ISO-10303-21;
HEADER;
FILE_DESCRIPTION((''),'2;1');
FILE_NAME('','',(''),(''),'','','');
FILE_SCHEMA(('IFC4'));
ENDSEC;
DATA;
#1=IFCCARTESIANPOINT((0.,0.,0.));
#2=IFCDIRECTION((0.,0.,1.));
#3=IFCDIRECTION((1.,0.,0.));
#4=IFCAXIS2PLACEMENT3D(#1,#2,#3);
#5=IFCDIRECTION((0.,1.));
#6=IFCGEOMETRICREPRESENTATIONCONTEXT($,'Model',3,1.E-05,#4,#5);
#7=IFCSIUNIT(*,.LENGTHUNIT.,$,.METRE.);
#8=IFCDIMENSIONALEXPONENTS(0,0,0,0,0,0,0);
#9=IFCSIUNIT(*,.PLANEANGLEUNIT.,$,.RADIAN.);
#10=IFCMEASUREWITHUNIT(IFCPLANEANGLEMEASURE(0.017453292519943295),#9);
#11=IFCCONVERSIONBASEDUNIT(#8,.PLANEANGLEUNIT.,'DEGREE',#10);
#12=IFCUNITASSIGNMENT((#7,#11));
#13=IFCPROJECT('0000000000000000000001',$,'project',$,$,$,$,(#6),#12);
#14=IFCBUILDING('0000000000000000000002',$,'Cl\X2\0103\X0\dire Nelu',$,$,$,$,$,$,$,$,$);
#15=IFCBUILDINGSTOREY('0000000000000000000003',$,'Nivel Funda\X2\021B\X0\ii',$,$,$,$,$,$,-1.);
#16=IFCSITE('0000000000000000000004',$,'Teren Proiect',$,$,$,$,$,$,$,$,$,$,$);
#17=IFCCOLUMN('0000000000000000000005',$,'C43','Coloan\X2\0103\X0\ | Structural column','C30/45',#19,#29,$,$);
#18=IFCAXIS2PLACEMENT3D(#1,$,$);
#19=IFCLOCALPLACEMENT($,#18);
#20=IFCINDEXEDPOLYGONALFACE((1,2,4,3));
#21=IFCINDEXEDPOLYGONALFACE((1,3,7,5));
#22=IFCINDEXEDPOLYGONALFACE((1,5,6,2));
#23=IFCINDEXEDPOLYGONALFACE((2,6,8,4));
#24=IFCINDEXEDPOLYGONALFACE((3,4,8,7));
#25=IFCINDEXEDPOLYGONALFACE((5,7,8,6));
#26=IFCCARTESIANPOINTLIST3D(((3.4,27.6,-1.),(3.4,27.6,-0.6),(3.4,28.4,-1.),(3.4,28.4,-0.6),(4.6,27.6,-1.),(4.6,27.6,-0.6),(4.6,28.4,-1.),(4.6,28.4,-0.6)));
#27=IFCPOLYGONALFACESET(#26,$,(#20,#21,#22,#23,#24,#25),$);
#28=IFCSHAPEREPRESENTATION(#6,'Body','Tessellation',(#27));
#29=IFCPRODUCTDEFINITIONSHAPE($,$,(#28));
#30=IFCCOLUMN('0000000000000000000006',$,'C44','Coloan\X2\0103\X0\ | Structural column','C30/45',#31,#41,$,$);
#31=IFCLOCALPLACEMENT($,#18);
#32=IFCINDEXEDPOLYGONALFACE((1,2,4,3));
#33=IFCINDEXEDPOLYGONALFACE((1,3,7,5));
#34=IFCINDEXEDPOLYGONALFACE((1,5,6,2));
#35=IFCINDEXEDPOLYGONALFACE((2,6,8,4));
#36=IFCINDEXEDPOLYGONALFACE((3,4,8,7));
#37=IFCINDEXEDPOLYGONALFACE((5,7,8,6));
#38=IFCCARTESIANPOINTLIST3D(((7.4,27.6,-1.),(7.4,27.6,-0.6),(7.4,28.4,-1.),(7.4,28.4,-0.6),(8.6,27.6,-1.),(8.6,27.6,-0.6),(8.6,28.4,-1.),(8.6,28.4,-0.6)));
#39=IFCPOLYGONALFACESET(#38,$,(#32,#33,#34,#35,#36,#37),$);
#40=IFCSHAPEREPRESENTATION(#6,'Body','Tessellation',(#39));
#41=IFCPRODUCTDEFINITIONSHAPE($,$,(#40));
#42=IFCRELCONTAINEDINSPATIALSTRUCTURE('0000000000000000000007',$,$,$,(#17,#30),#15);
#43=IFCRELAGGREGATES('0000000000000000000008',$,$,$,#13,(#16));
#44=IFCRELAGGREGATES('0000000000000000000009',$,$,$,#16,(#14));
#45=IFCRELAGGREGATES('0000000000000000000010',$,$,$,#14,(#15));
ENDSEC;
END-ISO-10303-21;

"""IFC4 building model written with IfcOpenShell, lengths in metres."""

from ifc_helpers import new_model, entity, si_unit, converted_unit, direction, frame, origin_with_axes, place, context, project, spatial, rectangle, extrude, element, save


model = new_model("IFC4")

# Units and contexts
model_context = context("Model", 3, precision=1e-05, world=origin_with_axes(), true_north=direction((0.0, 1.0)))
ifc_project = project(units=[si_unit("LENGTHUNIT", "METRE"), converted_unit("PLANEANGLEUNIT", "DEGREE", entity("IfcPlaneAngleMeasure", 0.017453292519943295), si_unit("PLANEANGLEUNIT", "RADIAN"), dimensions=[0, 0, 0, 0, 0, 0, 0])], contexts=[model_context])

# Site, building, storey
site = spatial("IfcSite", under=ifc_project, Name="Teren Proiect")
building = spatial("IfcBuilding", under=site, Name="Clădire Nelu")
storey = spatial("IfcBuildingStorey", under=building, Name="Nivel Fundații", Elevation=-1.0)

# Columns
for number, where, z_axis, x_axis, name in (
    (1, (4.0, 28.0, -1.0), (0.0, 0.0, 1.0), (1.0, 0.0, 0.0), "C43"),
    (2, (8.0, 28.0, -1.0), (0.0, 0.0, 1.0), (1.0, 0.0, 0.0), "C44"),
):
    element("IfcColumn", number, at=place(None, frame(where, z_axis=z_axis, x_axis=x_axis)), inside=storey, Name=name, Description="Coloană | Structural column", ObjectType="C30/45", context=model_context, shape_type="SweptSolid", body=[
        extrude(rectangle(XDim=1.2, YDim=0.8), None, (0.0, 0.0, 1.0), 0.4),
    ])

save(model, "model.ifc")
